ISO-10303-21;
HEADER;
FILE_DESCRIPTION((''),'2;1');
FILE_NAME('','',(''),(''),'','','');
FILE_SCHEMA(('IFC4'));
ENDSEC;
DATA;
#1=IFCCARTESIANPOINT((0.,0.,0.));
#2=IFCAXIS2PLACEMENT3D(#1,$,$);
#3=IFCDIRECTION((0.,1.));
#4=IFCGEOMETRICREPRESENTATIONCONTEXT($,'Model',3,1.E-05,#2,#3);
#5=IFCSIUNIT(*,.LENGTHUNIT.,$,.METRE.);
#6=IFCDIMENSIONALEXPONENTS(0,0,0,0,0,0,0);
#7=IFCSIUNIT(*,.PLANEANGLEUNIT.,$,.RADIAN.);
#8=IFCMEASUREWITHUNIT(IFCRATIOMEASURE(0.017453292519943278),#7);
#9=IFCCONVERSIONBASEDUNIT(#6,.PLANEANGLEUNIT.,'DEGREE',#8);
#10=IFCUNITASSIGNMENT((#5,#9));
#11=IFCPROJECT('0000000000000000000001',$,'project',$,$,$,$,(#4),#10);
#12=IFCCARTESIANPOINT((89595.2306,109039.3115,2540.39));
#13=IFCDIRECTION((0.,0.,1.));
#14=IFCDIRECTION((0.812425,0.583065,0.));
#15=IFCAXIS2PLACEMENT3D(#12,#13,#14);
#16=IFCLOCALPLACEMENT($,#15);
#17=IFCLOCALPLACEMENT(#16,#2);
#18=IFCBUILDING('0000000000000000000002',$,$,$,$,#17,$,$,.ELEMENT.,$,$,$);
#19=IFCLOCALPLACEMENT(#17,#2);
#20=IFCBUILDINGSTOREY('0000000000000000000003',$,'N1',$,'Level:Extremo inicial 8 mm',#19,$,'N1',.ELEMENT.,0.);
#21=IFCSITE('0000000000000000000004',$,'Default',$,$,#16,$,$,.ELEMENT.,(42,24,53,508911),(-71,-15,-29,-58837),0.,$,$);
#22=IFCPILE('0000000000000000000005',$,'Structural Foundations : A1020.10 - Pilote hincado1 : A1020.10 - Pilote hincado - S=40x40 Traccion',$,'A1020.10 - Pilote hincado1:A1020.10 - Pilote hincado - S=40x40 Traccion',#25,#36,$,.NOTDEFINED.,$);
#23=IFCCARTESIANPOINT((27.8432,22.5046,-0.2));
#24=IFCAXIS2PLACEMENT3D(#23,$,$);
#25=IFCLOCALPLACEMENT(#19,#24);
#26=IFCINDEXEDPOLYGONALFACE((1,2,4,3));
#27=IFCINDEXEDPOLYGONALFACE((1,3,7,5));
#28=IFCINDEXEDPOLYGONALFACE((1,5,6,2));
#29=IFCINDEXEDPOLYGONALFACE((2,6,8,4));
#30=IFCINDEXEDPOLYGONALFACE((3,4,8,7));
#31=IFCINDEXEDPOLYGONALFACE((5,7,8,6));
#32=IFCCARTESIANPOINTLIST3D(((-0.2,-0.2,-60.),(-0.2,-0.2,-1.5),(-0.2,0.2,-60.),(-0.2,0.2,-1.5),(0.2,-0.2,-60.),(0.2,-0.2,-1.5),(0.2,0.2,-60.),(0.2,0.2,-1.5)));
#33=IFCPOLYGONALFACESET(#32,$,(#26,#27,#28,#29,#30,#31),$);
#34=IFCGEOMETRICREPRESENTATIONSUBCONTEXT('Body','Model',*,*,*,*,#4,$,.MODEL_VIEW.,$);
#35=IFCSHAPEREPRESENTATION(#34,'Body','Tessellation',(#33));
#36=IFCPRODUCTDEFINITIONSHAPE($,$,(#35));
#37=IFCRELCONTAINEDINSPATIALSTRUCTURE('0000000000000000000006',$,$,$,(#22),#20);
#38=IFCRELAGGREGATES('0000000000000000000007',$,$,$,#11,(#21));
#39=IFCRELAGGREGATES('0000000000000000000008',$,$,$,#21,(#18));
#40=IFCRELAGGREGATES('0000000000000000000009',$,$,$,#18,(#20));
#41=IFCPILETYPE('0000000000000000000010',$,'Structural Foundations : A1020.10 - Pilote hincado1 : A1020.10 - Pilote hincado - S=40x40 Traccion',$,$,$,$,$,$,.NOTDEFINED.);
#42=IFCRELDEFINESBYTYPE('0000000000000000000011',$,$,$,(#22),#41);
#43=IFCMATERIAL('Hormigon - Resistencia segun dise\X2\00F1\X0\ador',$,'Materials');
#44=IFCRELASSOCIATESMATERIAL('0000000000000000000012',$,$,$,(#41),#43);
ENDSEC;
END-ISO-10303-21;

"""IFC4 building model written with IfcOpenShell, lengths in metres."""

from ifc_helpers import new_model, entity, si_unit, converted_unit, direction, frame, origin, origin_2d_with_axis, place, context, subcontext, project, spatial, polyline, segment, composite_curve, rectangle, outline, extrude, source, transform, mapped, material, material_profile, profile_set, type_object, type_shapes, element, save


model = new_model("IFC4")

# Units and contexts
model_context = context("Model", 3, precision=1e-05, world=origin(), true_north=direction((0.0, 1.0)))
body_context = subcontext(model_context, "Body", "Model", "MODEL_VIEW")
ifc_project = project(units=[si_unit("LENGTHUNIT", "METRE"), converted_unit("PLANEANGLEUNIT", "DEGREE", entity("IfcRatioMeasure", 0.017453292519943278), si_unit("PLANEANGLEUNIT", "RADIAN"), dimensions=[0, 0, 0, 0, 0, 0, 0])], contexts=[model_context])

# Site, building, storey
site_placement = place(None, frame((89595.2306, 109039.3115, 2540.39), z_axis=(0.0, 0.0, 1.0), x_axis=(0.812425, 0.583065, 0.0)))
site = spatial("IfcSite", under=ifc_project, at=site_placement, Name="Default", CompositionType="ELEMENT", RefLatitude=(42, 24, 53, 508911), RefLongitude=(-71, -15, -29, -58837), RefElevation=0.0)
building_placement = place(site_placement, origin())
building = spatial("IfcBuilding", under=site, at=building_placement, CompositionType="ELEMENT")
storey_placement = place(building_placement, origin())
storey = spatial("IfcBuildingStorey", under=building, at=storey_placement, Name="N1", ObjectType="Level:Extremo inicial 8 mm", LongName="N1", CompositionType="ELEMENT", Elevation=0.0)

# Pile
ifc_material_1 = material(Name="Hormigon - Resistencia segun diseñador", Category="Materials")
ifc_material_profile_1 = material_profile(ifc_material_1, outline(composite_curve([segment(polyline([(0.2, -0.2, -1.5), (0.2, 0.2, -1.5)]), True, "CONTINUOUS"), segment(polyline([(0.2, 0.2, -1.5), (-0.2, 0.2, -1.5)]), True, "CONTINUOUS"), segment(polyline([(-0.2, 0.2, -1.5), (-0.2, -0.2, -1.5)]), True, "CONTINUOUS"), segment(polyline([(-0.2, -0.2, -1.5), (0.2, -0.2, -1.5)]), True, "CONTINUOUS")], self_intersect=False), kind="CURVE"), Name="A1020.10 - Pilote hincado - S=40x40 Traccion")
ifc_profile_set_1 = profile_set([ifc_material_profile_1], Name="A1020.10 - Pilote hincado - S=40x40 Traccion")
pile_type_1 = type_object("IfcPileType", Name="Structural Foundations : A1020.10 - Pilote hincado1 : A1020.10 - Pilote hincado - S=40x40 Traccion", PredefinedType="NOTDEFINED", material=ifc_profile_set_1)
shared_shape_1 = source(origin(), body_context, "Body", "SweptSolid", [
    extrude(rectangle(XDim=0.4, YDim=0.4, at=origin_2d_with_axis()), frame((0.0, 0.0, -60.0), z_axis=(0.0, 0.0, 1.0), x_axis=(0.0, -1.0, 0.0)), (0.0, 0.0, 1.0), 58.5),
])
type_shapes(pile_type_1, [shared_shape_1])
pile_1_placement = place(storey_placement, frame((27.8432, 22.5046, -0.2)))
element("IfcPile", 1, at=pile_1_placement, inside=storey, type_object=pile_type_1, Name="Structural Foundations : A1020.10 - Pilote hincado1 : A1020.10 - Pilote hincado - S=40x40 Traccion", ObjectType="A1020.10 - Pilote hincado1:A1020.10 - Pilote hincado - S=40x40 Traccion", PredefinedType="NOTDEFINED", context=body_context, shape_type="MappedRepresentation", body=[
    mapped(shared_shape_1, transform((0.0, 0.0, 0.0), scale=1.0)),
])

save(model, "model.ifc")
